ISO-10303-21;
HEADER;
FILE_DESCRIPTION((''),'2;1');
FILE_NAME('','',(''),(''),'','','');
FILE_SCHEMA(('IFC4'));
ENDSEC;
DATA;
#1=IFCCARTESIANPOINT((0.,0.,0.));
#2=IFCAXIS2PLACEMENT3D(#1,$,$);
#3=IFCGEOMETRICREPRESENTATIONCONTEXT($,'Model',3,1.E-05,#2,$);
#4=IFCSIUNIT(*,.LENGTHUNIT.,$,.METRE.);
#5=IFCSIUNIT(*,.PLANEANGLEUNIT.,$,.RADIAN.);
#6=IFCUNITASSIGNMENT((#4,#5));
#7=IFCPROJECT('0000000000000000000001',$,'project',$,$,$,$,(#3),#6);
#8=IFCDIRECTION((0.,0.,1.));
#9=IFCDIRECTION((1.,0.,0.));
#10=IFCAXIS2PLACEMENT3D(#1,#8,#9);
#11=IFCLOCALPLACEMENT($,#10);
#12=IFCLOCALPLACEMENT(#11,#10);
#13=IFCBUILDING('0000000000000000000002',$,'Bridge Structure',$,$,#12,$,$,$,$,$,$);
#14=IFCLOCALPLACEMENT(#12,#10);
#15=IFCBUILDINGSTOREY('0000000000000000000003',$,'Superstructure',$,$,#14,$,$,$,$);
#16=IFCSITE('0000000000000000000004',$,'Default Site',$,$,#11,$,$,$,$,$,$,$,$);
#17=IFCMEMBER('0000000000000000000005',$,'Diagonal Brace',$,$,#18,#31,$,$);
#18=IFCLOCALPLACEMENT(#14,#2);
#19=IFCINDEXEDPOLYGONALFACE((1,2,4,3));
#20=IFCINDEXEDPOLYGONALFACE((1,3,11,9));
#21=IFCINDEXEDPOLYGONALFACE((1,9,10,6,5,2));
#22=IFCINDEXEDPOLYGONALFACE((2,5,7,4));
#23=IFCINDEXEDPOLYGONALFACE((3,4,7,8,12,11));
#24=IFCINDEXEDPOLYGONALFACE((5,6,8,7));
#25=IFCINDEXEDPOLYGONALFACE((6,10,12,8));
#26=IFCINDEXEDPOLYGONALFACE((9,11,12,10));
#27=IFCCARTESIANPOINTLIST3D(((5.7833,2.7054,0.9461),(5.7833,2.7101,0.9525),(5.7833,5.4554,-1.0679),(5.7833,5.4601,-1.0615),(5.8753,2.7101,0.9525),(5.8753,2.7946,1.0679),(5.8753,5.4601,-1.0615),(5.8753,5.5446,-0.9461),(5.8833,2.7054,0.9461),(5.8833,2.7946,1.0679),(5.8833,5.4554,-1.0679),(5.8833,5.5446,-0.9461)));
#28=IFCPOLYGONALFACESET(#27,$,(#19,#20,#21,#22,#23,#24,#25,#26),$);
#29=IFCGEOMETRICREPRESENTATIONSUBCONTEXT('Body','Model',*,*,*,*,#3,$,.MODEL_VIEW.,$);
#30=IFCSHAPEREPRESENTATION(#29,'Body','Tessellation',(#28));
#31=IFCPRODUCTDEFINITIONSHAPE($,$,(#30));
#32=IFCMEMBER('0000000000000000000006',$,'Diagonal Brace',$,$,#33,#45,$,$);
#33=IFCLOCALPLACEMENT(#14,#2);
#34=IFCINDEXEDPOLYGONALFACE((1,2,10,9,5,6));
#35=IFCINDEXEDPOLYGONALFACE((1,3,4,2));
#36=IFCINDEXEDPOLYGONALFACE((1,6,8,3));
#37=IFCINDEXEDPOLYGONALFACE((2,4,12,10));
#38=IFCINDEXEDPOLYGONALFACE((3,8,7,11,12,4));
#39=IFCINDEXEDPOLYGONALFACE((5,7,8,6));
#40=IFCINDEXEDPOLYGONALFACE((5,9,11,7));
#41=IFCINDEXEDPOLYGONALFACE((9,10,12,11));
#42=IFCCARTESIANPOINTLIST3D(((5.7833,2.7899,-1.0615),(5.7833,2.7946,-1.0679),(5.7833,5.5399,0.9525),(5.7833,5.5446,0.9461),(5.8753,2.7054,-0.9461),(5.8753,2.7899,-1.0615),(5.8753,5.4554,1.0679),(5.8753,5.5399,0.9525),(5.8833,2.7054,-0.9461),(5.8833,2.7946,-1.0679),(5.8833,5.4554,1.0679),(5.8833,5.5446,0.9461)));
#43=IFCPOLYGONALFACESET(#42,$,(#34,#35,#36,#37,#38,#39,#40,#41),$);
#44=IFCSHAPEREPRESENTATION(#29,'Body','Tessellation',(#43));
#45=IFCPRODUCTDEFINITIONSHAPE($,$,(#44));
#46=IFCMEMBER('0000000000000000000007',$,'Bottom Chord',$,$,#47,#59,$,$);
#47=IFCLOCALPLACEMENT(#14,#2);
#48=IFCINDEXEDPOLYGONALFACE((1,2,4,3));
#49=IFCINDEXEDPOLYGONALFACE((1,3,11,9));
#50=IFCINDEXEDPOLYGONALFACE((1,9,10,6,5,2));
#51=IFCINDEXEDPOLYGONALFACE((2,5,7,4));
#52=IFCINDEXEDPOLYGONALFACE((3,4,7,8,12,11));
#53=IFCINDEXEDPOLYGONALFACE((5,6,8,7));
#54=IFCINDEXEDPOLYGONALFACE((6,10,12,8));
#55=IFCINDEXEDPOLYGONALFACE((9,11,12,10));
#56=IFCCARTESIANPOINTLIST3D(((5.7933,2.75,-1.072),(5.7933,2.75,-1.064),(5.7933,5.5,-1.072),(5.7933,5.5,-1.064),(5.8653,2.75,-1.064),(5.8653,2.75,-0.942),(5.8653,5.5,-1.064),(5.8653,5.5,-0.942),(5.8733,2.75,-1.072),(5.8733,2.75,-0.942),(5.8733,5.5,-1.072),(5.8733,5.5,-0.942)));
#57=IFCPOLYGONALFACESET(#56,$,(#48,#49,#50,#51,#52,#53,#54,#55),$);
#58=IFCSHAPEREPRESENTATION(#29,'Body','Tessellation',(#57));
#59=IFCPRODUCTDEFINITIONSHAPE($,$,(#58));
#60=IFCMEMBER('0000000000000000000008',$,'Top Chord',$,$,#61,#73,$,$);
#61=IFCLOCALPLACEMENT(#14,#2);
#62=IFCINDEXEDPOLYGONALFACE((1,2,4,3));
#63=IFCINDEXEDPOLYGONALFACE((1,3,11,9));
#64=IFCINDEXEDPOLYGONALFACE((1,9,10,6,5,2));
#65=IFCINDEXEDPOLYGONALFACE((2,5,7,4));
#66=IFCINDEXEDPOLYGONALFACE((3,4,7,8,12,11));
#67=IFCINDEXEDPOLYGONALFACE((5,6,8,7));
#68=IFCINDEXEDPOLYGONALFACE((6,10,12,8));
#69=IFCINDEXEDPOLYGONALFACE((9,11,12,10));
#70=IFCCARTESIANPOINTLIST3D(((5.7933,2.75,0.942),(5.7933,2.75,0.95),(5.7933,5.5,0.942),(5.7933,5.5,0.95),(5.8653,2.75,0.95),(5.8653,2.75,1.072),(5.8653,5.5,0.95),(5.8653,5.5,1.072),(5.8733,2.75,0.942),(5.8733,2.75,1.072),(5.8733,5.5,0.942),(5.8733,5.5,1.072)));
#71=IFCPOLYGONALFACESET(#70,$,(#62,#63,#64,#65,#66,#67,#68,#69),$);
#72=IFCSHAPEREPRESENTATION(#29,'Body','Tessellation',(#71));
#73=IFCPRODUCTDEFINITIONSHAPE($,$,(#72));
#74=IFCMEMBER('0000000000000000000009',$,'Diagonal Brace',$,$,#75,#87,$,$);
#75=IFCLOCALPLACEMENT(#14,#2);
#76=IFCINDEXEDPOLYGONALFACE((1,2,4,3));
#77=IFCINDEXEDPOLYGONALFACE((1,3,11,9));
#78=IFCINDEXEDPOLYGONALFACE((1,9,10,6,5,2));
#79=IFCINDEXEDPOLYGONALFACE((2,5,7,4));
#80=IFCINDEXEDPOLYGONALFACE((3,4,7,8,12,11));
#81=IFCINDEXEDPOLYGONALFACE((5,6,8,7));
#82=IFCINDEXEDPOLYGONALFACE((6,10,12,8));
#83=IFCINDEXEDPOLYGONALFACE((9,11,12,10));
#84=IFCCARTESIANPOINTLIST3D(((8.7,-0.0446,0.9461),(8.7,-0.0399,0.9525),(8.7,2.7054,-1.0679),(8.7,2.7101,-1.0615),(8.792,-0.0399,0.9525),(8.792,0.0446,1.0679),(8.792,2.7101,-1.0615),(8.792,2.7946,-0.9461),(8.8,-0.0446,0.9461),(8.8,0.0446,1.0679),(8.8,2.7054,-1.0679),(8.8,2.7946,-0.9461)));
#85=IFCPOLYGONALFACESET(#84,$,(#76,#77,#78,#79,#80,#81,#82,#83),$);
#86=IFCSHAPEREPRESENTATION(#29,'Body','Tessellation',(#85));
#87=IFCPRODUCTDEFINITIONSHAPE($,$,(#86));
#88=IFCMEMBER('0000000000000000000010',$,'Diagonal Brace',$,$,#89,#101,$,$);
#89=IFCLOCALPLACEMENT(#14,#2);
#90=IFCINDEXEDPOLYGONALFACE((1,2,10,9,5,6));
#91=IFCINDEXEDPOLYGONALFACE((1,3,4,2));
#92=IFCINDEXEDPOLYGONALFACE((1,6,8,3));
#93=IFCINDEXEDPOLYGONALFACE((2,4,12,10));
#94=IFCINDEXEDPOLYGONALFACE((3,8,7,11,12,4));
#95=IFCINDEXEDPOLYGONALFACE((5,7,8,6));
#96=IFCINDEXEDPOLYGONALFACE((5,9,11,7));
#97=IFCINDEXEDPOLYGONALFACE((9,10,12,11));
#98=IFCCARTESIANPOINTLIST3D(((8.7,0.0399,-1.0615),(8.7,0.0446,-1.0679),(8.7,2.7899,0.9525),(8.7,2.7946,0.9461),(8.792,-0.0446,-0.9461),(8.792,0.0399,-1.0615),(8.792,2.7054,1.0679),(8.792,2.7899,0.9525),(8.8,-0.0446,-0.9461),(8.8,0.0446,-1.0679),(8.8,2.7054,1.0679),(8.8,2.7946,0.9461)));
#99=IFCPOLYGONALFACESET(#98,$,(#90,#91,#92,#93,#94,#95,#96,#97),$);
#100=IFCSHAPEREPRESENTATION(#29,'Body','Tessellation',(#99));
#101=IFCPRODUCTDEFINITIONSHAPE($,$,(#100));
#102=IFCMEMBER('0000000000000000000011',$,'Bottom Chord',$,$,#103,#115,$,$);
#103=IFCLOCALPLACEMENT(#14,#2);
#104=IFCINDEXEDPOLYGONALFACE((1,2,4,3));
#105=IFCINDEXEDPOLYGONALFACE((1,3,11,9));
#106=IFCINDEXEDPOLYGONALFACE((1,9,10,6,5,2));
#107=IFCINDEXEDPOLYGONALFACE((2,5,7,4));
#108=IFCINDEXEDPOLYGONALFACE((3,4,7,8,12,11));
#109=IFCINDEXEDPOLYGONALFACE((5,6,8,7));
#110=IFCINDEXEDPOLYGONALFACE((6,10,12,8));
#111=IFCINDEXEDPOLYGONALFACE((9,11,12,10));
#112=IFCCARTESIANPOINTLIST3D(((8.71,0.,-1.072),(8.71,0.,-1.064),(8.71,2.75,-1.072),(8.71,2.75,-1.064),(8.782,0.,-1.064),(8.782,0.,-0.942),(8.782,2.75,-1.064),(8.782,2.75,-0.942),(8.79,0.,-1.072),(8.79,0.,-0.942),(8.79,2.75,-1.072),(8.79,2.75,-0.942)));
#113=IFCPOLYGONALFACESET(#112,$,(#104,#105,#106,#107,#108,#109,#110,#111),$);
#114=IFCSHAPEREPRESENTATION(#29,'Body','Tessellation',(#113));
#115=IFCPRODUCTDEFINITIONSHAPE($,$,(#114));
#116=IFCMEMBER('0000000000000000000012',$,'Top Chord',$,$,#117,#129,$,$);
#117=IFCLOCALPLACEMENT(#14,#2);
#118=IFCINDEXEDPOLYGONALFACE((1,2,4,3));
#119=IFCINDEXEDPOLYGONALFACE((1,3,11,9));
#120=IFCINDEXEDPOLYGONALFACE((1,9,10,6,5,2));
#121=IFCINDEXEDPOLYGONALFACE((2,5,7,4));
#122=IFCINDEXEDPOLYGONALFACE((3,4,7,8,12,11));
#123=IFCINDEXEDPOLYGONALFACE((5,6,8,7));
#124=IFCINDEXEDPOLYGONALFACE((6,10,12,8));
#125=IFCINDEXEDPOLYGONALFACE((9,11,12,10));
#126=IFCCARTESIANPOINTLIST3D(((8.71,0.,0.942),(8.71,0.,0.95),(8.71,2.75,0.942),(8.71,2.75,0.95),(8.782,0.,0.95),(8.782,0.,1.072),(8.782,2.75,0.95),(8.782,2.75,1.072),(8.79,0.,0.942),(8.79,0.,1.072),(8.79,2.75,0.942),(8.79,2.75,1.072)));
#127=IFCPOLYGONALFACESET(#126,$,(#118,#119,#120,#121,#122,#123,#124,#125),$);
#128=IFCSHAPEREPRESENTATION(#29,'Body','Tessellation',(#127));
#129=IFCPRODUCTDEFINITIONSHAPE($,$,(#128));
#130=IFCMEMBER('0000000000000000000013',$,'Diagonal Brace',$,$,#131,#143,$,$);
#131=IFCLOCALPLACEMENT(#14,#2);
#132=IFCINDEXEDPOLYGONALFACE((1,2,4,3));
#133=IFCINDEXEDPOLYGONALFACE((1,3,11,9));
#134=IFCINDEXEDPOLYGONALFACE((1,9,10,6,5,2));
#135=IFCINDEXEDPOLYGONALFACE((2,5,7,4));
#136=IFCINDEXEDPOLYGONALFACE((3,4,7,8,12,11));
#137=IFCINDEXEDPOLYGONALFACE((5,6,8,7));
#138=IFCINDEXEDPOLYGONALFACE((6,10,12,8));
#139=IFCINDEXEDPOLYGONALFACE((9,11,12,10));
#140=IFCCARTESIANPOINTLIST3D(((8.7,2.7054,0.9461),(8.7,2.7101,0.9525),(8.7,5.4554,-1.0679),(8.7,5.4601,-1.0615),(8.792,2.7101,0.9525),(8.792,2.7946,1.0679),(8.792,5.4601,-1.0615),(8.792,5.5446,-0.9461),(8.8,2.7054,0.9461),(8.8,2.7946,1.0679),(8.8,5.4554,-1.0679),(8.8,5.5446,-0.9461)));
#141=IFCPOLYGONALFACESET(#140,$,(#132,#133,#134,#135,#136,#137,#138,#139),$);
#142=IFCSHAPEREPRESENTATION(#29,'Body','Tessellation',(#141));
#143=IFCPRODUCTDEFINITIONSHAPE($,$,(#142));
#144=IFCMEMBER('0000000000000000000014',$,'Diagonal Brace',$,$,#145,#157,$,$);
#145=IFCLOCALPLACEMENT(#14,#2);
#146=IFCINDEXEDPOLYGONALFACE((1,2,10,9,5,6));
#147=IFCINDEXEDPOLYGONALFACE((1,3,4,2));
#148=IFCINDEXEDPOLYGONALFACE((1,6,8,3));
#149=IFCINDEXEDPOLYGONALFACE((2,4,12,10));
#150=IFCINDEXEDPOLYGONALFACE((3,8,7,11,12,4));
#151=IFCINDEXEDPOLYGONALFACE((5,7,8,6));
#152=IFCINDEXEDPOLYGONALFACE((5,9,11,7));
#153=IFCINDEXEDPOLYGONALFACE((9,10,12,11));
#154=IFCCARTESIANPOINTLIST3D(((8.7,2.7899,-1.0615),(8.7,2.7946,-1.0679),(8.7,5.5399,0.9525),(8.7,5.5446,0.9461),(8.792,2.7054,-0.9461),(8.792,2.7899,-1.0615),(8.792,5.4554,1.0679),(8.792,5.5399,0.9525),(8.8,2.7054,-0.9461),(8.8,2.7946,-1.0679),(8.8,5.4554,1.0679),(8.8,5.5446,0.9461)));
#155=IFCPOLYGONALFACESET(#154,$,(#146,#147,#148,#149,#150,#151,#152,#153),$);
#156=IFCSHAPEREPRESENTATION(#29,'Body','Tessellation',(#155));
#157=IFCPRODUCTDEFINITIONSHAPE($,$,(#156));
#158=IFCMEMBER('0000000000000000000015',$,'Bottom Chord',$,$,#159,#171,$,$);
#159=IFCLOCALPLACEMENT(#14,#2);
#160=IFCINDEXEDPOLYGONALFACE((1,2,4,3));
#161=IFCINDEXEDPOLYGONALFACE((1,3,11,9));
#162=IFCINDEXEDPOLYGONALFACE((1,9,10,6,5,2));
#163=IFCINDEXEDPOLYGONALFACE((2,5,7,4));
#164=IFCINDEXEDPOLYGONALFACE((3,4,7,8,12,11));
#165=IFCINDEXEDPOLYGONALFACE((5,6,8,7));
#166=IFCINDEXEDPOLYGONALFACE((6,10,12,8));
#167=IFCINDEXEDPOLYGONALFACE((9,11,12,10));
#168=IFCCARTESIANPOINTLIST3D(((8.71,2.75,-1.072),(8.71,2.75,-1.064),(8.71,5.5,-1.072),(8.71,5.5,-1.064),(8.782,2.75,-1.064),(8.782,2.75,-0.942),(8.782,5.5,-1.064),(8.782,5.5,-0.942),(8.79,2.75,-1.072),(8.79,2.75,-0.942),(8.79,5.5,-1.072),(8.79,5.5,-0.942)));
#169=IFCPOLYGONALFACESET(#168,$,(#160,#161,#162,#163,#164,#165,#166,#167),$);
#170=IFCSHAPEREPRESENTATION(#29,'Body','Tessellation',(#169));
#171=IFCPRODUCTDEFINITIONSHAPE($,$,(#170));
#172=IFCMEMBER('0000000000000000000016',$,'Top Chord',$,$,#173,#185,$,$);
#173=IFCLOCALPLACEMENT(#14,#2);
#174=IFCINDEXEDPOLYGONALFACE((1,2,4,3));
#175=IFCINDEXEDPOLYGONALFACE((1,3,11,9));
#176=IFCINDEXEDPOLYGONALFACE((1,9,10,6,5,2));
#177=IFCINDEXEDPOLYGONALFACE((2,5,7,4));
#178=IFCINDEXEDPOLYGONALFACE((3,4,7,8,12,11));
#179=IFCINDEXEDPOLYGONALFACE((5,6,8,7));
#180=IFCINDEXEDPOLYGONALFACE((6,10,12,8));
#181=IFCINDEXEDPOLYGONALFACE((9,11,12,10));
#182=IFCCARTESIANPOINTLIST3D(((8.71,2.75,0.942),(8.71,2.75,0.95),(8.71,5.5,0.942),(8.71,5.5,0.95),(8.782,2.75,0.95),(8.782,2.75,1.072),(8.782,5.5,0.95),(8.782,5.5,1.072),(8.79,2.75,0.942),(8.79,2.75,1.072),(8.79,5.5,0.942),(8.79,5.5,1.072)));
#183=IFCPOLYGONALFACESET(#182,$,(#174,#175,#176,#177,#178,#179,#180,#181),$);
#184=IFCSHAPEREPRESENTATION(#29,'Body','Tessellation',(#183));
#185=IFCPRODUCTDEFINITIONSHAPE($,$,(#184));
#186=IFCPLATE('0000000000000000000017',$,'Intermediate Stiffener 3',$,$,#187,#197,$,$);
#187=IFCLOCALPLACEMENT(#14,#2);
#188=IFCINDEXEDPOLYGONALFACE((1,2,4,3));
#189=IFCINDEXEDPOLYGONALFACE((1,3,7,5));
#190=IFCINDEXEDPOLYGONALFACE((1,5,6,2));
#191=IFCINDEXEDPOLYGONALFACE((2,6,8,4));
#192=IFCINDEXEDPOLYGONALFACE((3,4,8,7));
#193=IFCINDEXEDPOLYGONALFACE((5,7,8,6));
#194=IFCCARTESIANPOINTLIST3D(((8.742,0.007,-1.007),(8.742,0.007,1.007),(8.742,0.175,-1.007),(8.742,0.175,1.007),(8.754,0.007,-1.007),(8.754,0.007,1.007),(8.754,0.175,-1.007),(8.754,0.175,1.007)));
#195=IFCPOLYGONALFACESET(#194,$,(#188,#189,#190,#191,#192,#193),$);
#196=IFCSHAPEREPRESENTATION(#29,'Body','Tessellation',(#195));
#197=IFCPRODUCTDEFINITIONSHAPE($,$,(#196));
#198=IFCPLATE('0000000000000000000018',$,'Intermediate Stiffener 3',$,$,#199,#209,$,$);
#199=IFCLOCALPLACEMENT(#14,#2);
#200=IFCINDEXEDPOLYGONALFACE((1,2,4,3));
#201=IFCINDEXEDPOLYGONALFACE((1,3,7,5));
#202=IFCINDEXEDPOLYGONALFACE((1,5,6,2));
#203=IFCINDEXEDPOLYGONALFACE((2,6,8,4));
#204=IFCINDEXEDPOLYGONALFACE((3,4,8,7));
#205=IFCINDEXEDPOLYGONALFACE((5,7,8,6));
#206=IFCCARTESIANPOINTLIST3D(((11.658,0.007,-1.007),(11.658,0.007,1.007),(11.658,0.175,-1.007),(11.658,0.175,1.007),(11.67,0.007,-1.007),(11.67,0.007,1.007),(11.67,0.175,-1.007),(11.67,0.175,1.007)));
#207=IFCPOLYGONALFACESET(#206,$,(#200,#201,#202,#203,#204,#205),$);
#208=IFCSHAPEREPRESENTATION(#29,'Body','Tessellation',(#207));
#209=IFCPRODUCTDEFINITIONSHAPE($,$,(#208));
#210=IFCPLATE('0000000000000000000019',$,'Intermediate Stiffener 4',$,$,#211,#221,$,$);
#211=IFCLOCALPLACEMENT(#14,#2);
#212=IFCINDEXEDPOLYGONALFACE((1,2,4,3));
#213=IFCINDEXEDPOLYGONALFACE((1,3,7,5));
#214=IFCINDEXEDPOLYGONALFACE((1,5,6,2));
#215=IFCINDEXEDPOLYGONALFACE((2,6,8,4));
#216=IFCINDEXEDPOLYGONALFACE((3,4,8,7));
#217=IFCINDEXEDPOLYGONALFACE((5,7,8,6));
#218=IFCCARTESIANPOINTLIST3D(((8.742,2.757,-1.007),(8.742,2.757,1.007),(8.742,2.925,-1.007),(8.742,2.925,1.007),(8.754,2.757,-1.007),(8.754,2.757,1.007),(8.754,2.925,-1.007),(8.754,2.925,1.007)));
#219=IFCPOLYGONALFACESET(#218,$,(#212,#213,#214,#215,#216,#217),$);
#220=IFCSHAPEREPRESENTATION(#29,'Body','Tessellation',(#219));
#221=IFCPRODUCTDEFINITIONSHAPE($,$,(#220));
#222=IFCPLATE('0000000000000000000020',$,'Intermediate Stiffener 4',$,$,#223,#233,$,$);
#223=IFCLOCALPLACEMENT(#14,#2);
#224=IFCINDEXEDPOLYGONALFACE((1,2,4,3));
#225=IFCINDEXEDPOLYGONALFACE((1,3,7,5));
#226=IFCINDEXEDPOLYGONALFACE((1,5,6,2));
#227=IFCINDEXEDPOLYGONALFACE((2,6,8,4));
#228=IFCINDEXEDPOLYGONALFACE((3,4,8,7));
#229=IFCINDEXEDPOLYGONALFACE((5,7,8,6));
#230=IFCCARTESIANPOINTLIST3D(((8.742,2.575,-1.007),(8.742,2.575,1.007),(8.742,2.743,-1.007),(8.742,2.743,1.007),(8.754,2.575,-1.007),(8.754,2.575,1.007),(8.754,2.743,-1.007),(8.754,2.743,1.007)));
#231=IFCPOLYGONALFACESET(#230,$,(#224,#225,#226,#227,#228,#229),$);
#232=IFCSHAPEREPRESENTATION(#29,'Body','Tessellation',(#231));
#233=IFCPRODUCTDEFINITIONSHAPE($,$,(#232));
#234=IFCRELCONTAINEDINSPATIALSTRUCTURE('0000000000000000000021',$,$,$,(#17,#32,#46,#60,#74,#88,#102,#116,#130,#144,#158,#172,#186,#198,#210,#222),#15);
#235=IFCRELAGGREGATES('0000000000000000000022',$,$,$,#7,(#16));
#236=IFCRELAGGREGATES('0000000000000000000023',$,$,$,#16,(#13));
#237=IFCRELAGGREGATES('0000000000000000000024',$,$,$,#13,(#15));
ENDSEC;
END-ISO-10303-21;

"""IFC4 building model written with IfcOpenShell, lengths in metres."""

from ifc_helpers import new_model, si_unit, frame, origin, origin_with_axes, origin_2d_with_axis, place, context, subcontext, project, spatial, rectangle, l_section, extrude, element, save


model = new_model("IFC4")

# Units and contexts
model_context = context("Model", 3, precision=1e-05, world=origin())
body_context = subcontext(model_context, "Body", "Model", "MODEL_VIEW")
ifc_project = project(units=[si_unit("LENGTHUNIT", "METRE"), si_unit("PLANEANGLEUNIT", "RADIAN")], contexts=[model_context])

# Site, building, storey
site_placement = place(None, origin_with_axes())
site = spatial("IfcSite", under=ifc_project, at=site_placement, Name="Default Site")
building_placement = place(site_placement, origin_with_axes())
building = spatial("IfcBuilding", under=site, at=building_placement, Name="Bridge Structure")
storey_placement = place(building_placement, origin_with_axes())
storey = spatial("IfcBuildingStorey", under=building, at=storey_placement, Name="Superstructure")

# Members
for number, where, z_axis, x_axis, name in (
    (1, (5.8333, 2.75, 1.007), (0.0, 0.806778, -0.590855), (-1.0, 0.0, 0.0), "Diagonal Brace"),
    (2, (5.8333, 2.75, -1.007), (0.0, 0.806778, 0.590855), (-1.0, 0.0, 0.0), "Diagonal Brace"),
):
    element("IfcMember", number, at=place(storey_placement, frame(where, z_axis=z_axis, x_axis=x_axis)), inside=storey, Name=name, context=body_context, shape_type="SweptSolid", body=[
        extrude(l_section(Depth=0.151, Width=0.1, Thickness=0.008, at=origin_2d_with_axis()), origin_with_axes(), (0.0, 0.0, 1.0), 3.4086),
    ])
for number, where, z_axis, x_axis, name in (
    (3, (5.8333, 2.75, -1.007), (0.0, 1.0, 0.0), (-1.0, 0.0, 0.0), "Bottom Chord"),
    (4, (5.8333, 2.75, 1.007), (0.0, 1.0, 0.0), (-1.0, 0.0, 0.0), "Top Chord"),
):
    element("IfcMember", number, at=place(storey_placement, frame(where, z_axis=z_axis, x_axis=x_axis)), inside=storey, Name=name, context=body_context, shape_type="SweptSolid", body=[
        extrude(l_section(Depth=0.13, Width=0.08, Thickness=0.008, at=origin_2d_with_axis()), origin_with_axes(), (0.0, 0.0, 1.0), 2.75),
    ])
for number, where, z_axis, x_axis, name in (
    (5, (8.75, 0.0, 1.007), (0.0, 0.806778, -0.590855), (-1.0, 0.0, 0.0), "Diagonal Brace"),
    (6, (8.75, 0.0, -1.007), (0.0, 0.806778, 0.590855), (-1.0, 0.0, 0.0), "Diagonal Brace"),
):
    element("IfcMember", number, at=place(storey_placement, frame(where, z_axis=z_axis, x_axis=x_axis)), inside=storey, Name=name, context=body_context, shape_type="SweptSolid", body=[
        extrude(l_section(Depth=0.151, Width=0.1, Thickness=0.008, at=origin_2d_with_axis()), origin_with_axes(), (0.0, 0.0, 1.0), 3.4086),
    ])
for number, where, z_axis, x_axis, name in (
    (7, (8.75, 0.0, -1.007), (0.0, 1.0, 0.0), (-1.0, 0.0, 0.0), "Bottom Chord"),
    (8, (8.75, 0.0, 1.007), (0.0, 1.0, 0.0), (-1.0, 0.0, 0.0), "Top Chord"),
):
    element("IfcMember", number, at=place(storey_placement, frame(where, z_axis=z_axis, x_axis=x_axis)), inside=storey, Name=name, context=body_context, shape_type="SweptSolid", body=[
        extrude(l_section(Depth=0.13, Width=0.08, Thickness=0.008, at=origin_2d_with_axis()), origin_with_axes(), (0.0, 0.0, 1.0), 2.75),
    ])
for number, where, z_axis, x_axis, name in (
    (9, (8.75, 2.75, 1.007), (0.0, 0.806778, -0.590855), (-1.0, 0.0, 0.0), "Diagonal Brace"),
    (10, (8.75, 2.75, -1.007), (0.0, 0.806778, 0.590855), (-1.0, 0.0, 0.0), "Diagonal Brace"),
):
    element("IfcMember", number, at=place(storey_placement, frame(where, z_axis=z_axis, x_axis=x_axis)), inside=storey, Name=name, context=body_context, shape_type="SweptSolid", body=[
        extrude(l_section(Depth=0.151, Width=0.1, Thickness=0.008, at=origin_2d_with_axis()), origin_with_axes(), (0.0, 0.0, 1.0), 3.4086),
    ])
for number, where, z_axis, x_axis, name in (
    (11, (8.75, 2.75, -1.007), (0.0, 1.0, 0.0), (-1.0, 0.0, 0.0), "Bottom Chord"),
    (12, (8.75, 2.75, 1.007), (0.0, 1.0, 0.0), (-1.0, 0.0, 0.0), "Top Chord"),
):
    element("IfcMember", number, at=place(storey_placement, frame(where, z_axis=z_axis, x_axis=x_axis)), inside=storey, Name=name, context=body_context, shape_type="SweptSolid", body=[
        extrude(l_section(Depth=0.13, Width=0.08, Thickness=0.008, at=origin_2d_with_axis()), origin_with_axes(), (0.0, 0.0, 1.0), 2.75),
    ])

# Plates
for number, where, z_axis, x_axis, name in (
    (13, (8.748, 0.091, -1.007), (0.0, 0.0, 1.0), (1.0, 0.0, 0.0), "Intermediate Stiffener 3"),
    (14, (11.664, 0.091, -1.007), (0.0, 0.0, 1.0), (1.0, 0.0, 0.0), "Intermediate Stiffener 3"),
    (15, (8.748, 2.841, -1.007), (0.0, 0.0, 1.0), (1.0, 0.0, 0.0), "Intermediate Stiffener 4"),
    (16, (8.748, 2.659, -1.007), (0.0, 0.0, 1.0), (1.0, 0.0, 0.0), "Intermediate Stiffener 4"),
):
    element("IfcPlate", number, at=place(storey_placement, frame(where, z_axis=z_axis, x_axis=x_axis)), inside=storey, Name=name, context=body_context, shape_type="SweptSolid", body=[
        extrude(rectangle(XDim=0.012, YDim=0.168, at=origin_2d_with_axis()), origin_with_axes(), (0.0, 0.0, 1.0), 2.014),
    ])

save(model, "model.ifc")
